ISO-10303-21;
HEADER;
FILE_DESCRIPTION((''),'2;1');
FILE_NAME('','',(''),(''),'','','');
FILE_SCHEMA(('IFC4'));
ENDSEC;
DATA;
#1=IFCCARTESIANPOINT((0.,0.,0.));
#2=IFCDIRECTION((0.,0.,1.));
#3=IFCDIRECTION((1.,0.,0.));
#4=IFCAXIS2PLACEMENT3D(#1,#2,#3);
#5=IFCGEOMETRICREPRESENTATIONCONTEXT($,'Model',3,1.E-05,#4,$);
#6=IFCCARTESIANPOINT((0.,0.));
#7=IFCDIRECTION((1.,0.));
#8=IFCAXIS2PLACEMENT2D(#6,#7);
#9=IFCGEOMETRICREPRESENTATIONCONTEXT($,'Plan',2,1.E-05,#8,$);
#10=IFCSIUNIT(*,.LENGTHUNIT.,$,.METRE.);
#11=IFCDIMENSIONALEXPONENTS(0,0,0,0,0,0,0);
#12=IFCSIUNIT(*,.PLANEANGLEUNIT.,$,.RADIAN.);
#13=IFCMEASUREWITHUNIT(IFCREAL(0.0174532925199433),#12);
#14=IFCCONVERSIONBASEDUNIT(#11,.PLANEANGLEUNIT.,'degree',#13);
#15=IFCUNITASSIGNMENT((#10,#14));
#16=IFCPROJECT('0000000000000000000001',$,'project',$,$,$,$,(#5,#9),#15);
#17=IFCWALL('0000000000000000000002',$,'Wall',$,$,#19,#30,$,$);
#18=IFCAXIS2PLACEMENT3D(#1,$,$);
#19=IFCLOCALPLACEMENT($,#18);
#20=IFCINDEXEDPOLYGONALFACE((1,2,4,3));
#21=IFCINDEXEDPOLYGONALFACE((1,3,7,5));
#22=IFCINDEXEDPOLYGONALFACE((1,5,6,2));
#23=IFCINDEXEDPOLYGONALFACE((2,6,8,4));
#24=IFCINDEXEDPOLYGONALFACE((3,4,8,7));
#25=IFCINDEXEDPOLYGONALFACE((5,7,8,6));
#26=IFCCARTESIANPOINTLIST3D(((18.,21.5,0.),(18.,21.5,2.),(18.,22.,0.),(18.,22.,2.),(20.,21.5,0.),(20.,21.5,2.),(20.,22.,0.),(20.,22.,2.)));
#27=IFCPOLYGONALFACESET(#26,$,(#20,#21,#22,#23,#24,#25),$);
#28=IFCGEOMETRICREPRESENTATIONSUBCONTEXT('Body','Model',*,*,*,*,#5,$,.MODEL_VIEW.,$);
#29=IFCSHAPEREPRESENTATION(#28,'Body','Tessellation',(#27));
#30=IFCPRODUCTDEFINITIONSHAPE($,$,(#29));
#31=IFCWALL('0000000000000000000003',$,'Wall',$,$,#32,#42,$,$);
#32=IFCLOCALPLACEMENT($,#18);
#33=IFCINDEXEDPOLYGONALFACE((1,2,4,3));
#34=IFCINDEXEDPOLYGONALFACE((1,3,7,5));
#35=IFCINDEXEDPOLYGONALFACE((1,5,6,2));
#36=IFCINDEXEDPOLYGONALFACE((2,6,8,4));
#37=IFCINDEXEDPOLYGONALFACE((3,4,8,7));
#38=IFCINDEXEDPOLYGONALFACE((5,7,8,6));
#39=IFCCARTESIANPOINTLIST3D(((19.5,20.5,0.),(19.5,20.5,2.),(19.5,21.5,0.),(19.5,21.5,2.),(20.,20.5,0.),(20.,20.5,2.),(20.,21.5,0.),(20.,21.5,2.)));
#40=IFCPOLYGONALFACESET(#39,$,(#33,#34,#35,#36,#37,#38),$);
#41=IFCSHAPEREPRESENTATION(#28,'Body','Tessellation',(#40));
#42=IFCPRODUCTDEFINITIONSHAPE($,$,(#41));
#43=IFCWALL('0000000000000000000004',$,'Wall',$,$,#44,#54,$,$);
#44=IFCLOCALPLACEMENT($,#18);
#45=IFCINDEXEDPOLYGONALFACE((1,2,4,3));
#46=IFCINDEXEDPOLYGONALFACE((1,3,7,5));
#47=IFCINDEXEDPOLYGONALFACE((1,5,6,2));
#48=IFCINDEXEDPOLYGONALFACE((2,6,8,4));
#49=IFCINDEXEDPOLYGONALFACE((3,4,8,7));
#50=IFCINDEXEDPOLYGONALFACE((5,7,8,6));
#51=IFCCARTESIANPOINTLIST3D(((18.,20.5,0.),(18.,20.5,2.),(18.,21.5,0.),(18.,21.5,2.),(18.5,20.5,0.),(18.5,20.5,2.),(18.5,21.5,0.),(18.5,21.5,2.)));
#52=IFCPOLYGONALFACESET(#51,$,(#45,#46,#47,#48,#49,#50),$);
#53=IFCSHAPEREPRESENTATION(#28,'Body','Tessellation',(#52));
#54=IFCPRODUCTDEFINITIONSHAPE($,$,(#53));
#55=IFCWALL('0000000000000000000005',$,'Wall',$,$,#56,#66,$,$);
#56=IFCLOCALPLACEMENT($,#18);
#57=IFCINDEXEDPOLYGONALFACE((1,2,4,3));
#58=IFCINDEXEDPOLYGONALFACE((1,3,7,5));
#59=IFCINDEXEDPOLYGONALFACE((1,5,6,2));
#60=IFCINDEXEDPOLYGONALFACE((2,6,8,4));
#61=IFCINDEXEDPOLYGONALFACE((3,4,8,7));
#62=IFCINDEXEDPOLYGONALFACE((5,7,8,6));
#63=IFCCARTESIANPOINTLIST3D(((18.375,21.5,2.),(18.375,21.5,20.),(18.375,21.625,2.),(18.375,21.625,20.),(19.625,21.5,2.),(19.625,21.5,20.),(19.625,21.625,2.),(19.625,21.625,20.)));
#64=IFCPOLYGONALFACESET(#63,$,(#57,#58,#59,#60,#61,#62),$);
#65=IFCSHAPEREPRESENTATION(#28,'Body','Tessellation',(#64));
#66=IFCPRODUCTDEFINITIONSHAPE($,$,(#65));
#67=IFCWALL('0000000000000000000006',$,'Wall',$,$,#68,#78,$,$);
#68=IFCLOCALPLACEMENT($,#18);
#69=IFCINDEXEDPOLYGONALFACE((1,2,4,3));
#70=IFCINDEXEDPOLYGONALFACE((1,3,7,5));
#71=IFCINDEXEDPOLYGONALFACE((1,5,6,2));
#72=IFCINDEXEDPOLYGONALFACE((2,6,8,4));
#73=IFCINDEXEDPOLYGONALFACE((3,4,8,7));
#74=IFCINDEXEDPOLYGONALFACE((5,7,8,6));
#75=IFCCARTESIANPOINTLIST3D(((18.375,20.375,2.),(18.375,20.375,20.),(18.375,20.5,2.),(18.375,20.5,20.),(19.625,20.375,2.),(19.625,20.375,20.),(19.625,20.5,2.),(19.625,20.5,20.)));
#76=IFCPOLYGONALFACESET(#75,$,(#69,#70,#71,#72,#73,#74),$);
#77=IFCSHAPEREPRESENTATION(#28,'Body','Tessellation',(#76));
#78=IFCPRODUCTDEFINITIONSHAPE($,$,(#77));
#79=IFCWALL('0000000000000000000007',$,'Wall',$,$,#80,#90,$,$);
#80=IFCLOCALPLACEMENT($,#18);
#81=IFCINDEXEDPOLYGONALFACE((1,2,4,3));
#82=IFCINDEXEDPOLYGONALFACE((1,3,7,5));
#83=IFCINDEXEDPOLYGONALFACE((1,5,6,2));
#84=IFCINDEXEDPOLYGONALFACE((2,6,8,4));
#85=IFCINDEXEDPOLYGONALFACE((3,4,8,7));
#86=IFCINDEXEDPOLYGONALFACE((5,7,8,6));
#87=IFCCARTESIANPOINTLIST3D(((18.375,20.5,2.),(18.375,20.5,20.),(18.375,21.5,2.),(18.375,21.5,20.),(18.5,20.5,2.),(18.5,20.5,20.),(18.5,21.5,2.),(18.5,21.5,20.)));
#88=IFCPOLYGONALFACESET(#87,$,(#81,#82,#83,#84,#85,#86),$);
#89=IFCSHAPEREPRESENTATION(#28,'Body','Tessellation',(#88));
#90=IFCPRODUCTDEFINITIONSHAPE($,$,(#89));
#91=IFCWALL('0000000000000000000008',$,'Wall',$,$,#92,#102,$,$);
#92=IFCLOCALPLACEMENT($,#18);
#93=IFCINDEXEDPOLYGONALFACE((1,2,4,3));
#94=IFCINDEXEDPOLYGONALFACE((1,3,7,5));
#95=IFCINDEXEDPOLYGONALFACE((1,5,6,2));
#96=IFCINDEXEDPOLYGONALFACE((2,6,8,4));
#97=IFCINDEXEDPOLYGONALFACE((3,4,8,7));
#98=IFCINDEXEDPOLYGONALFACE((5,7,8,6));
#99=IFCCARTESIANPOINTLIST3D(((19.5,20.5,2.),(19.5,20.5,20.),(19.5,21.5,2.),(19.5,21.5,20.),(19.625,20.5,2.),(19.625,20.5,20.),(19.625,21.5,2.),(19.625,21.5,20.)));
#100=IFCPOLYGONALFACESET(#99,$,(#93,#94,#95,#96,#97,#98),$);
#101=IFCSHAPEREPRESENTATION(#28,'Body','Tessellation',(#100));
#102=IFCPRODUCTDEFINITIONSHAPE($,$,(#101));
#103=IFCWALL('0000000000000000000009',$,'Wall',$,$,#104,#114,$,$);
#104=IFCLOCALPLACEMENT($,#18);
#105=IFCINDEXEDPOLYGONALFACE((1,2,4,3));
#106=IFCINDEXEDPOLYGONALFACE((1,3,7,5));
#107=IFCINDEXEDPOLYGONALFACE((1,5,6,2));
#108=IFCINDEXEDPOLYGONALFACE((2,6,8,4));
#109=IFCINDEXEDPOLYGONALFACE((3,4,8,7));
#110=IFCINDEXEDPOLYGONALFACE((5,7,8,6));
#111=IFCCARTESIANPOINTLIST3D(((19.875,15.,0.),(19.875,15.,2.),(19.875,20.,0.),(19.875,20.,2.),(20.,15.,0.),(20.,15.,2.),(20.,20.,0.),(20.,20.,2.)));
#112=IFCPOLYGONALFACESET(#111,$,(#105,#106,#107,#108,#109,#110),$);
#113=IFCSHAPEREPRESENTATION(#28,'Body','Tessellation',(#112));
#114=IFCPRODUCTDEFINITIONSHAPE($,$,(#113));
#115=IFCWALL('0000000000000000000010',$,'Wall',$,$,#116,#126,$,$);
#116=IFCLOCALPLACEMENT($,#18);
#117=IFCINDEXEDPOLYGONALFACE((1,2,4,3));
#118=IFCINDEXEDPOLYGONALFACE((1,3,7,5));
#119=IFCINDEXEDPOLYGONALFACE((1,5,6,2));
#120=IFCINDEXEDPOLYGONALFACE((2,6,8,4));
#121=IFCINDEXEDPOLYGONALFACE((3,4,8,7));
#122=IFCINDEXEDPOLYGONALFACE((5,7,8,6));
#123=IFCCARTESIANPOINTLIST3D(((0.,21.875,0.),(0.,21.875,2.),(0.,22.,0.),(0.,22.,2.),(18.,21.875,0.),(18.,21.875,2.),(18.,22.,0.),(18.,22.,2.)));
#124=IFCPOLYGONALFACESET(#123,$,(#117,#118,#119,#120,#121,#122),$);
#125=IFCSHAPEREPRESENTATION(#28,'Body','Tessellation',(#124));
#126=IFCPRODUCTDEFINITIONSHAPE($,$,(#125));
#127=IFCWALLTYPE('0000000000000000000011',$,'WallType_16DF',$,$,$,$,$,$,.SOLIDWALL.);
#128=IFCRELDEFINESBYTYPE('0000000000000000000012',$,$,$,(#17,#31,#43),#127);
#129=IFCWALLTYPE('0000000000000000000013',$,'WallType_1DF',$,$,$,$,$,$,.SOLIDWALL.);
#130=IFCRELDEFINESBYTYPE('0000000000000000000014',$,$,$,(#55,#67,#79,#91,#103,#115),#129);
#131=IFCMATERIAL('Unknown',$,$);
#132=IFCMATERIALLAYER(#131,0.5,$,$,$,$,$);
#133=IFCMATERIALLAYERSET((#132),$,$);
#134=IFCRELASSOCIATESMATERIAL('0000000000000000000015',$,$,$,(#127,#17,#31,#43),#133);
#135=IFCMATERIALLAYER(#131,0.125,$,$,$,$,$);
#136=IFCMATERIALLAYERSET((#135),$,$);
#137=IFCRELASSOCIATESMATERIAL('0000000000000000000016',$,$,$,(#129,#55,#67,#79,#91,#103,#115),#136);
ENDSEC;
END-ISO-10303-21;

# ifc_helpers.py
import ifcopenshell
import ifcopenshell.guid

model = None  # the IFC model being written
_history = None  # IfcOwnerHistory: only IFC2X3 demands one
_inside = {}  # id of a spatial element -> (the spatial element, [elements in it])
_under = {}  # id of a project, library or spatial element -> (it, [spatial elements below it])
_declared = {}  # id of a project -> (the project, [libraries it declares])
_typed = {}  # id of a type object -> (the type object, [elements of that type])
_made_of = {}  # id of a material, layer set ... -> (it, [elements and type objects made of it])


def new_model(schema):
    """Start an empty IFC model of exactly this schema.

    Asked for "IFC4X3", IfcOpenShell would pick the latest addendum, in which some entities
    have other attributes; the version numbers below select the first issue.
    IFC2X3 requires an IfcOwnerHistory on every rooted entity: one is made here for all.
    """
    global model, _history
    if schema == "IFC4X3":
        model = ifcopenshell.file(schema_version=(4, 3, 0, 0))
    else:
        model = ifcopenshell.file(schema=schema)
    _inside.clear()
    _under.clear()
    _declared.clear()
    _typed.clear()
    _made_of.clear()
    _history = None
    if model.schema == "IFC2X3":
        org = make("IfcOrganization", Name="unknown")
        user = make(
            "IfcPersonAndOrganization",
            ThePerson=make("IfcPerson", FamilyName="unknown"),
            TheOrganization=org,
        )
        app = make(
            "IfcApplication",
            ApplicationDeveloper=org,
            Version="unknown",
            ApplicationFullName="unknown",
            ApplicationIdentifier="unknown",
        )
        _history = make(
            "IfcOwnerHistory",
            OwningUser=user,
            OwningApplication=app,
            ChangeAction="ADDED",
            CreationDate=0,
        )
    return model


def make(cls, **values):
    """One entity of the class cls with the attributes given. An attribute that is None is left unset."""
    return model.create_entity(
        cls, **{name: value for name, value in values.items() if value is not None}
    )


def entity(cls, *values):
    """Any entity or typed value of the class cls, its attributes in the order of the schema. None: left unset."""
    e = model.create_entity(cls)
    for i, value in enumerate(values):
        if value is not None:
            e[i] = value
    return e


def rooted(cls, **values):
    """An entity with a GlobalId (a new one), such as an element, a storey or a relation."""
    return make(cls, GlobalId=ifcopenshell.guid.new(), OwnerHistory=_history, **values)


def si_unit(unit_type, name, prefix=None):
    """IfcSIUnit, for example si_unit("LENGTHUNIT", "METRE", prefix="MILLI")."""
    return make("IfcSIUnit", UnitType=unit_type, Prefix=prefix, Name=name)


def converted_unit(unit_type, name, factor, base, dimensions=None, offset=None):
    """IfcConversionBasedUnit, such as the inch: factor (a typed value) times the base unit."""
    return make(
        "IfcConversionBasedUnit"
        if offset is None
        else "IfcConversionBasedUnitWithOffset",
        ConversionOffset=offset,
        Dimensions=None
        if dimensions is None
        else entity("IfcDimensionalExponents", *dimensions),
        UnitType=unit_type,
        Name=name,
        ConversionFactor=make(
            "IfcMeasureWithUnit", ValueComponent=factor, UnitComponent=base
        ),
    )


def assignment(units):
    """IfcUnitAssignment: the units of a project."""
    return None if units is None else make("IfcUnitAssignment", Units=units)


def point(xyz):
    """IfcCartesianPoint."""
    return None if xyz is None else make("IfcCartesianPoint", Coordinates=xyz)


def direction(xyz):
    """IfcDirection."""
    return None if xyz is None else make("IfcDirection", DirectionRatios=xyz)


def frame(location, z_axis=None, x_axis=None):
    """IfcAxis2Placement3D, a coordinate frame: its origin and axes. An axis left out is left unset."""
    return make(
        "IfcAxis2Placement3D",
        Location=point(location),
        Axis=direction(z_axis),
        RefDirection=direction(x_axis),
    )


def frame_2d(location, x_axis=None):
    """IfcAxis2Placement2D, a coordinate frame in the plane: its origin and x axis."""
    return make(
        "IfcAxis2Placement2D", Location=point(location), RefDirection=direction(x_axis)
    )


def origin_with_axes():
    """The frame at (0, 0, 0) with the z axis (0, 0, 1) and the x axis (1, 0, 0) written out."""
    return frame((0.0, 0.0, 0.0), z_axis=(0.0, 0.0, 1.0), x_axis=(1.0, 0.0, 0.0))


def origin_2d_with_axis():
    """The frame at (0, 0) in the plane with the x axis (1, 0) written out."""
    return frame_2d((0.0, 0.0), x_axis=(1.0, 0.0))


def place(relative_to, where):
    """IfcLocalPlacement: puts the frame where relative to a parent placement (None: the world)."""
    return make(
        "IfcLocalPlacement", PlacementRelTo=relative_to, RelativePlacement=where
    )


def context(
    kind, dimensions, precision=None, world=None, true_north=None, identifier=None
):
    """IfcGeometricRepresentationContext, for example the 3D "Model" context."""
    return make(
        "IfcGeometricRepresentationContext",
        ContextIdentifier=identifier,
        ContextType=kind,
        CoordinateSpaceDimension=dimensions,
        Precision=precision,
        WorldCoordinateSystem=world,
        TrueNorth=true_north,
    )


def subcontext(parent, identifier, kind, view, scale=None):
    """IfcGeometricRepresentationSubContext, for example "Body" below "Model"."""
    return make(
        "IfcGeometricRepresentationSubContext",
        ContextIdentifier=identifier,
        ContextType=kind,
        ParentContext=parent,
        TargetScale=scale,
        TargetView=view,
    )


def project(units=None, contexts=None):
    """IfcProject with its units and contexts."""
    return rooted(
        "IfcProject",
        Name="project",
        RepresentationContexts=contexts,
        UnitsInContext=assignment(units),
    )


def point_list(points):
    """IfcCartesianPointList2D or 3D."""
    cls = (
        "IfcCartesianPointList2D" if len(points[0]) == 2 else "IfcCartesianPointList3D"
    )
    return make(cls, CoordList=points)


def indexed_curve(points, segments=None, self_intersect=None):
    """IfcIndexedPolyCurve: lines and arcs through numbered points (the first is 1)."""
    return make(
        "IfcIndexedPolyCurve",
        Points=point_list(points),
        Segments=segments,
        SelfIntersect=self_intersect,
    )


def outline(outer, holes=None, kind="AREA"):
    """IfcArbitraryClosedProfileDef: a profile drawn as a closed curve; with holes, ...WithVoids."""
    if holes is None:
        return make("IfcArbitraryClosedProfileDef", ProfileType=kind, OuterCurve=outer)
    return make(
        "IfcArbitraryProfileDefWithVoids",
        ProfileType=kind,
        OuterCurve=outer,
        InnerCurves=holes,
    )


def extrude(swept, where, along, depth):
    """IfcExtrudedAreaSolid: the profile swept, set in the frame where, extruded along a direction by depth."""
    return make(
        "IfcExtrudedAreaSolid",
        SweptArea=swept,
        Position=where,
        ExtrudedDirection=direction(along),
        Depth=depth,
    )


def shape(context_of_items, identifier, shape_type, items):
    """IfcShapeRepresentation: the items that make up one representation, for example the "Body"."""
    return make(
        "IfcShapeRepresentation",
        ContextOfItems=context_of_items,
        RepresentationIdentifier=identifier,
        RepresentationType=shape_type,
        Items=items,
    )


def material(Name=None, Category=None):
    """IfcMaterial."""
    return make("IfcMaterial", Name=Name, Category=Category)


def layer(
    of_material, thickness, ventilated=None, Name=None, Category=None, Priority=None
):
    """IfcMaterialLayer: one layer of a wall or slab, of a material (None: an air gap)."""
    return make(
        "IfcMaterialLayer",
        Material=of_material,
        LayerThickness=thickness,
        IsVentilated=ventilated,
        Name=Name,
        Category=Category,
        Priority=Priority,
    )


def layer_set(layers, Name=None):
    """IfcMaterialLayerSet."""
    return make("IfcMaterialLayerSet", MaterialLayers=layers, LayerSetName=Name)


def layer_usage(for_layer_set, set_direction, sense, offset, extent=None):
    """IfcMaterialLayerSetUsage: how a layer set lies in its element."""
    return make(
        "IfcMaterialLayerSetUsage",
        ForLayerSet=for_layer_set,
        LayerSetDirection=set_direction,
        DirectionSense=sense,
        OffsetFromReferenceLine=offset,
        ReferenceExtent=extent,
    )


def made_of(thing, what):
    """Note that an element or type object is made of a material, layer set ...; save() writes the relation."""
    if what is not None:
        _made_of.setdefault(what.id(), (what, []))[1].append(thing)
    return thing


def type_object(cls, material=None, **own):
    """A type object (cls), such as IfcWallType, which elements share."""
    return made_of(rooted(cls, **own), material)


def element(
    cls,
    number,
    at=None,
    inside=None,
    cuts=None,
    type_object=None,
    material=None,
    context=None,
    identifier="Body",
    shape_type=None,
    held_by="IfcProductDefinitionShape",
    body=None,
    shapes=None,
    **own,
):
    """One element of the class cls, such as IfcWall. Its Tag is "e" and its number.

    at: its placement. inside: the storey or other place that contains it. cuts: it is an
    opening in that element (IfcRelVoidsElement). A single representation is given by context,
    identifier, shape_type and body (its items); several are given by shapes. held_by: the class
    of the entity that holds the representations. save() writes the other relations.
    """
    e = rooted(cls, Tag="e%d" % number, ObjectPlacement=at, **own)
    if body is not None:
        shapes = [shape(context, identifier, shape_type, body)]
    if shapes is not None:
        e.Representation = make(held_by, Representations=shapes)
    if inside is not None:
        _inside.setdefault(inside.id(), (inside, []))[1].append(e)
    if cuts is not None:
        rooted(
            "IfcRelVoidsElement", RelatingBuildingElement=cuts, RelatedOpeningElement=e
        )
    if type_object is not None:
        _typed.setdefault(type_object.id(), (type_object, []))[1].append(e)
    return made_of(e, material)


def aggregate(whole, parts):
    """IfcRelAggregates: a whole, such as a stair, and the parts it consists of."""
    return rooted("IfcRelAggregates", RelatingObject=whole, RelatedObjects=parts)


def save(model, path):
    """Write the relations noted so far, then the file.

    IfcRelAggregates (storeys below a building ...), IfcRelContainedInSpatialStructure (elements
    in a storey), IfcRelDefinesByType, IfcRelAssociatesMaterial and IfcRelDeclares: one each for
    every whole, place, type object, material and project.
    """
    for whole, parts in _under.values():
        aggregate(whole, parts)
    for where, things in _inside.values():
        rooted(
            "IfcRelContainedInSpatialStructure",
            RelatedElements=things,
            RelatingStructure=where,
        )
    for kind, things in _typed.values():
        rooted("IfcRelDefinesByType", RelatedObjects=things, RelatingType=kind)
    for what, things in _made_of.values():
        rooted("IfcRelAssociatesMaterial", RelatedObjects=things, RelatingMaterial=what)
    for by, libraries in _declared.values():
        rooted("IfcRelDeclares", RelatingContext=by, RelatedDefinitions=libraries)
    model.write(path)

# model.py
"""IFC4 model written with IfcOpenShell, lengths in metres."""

from ifc_helpers import new_model, entity, si_unit, converted_unit, frame, origin_with_axes, origin_2d_with_axis, place, context, subcontext, project, indexed_curve, outline, extrude, material, layer, layer_set, layer_usage, type_object, element, save


model = new_model("IFC4")

# Units and contexts
model_context = context("Model", 3, precision=1e-05, world=origin_with_axes())
plan_context = context("Plan", 2, precision=1e-05, world=origin_2d_with_axis())
body_context_1 = subcontext(model_context, "Body", "Model", "MODEL_VIEW")
ifc_project = project(units=[si_unit("LENGTHUNIT", "METRE"), converted_unit("PLANEANGLEUNIT", "degree", entity("IfcReal", 0.0174532925199433), si_unit("PLANEANGLEUNIT", "RADIAN"), dimensions=[0, 0, 0, 0, 0, 0, 0])], contexts=[model_context, plan_context])

# Walls
ifc_material = material(Name="Unknown")
ifc_layer_1 = layer(ifc_material, 0.5)
ifc_layer_set_1 = layer_set([ifc_layer_1])
ifc_layer_usage_1 = layer_usage(ifc_layer_set_1, "AXIS2", "POSITIVE", 0.0)
wall_type_1 = type_object("IfcWallType", Name="WallType_16DF", PredefinedType="SOLIDWALL", material=ifc_layer_set_1)
wall_1_placement = place(None, frame((18.0, 21.5, 0.0), z_axis=(0.0, 0.0, 1.0), x_axis=(1.0, 0.0, 0.0)))
element("IfcWall", 1, at=wall_1_placement, type_object=wall_type_1, material=ifc_layer_usage_1, Name="Wall", context=body_context_1, shape_type="SweptSolid", body=[
    extrude(outline(indexed_curve([(0.0, 0.0), (0.0, 0.5), (2.0, 0.5), (2.0, 0.0), (0.0, 0.0)], self_intersect=False)), origin_with_axes(), (0.0, 0.0, 1.0), 2.0),
])
ifc_layer_usage_2 = layer_usage(ifc_layer_set_1, "AXIS2", "POSITIVE", 0.0)
wall_2_placement = place(None, frame((20.0, 20.5, 0.0), z_axis=(0.0, 0.0, 1.0), x_axis=(0.0, 1.0, 0.0)))
element("IfcWall", 2, at=wall_2_placement, type_object=wall_type_1, material=ifc_layer_usage_2, Name="Wall", context=body_context_1, shape_type="SweptSolid", body=[
    extrude(outline(indexed_curve([(0.0, 0.0), (0.0, 0.5), (1.0, 0.5), (1.0, 0.0), (0.0, 0.0)], self_intersect=False)), origin_with_axes(), (0.0, 0.0, 1.0), 2.0),
])
ifc_layer_usage_3 = layer_usage(ifc_layer_set_1, "AXIS2", "POSITIVE", 0.0)
wall_3_placement = place(None, frame((18.0, 21.5, 0.0), z_axis=(0.0, 0.0, 1.0), x_axis=(0.0, -1.0, 0.0)))
element("IfcWall", 3, at=wall_3_placement, type_object=wall_type_1, material=ifc_layer_usage_3, Name="Wall", context=body_context_1, shape_type="SweptSolid", body=[
    extrude(outline(indexed_curve([(0.0, 0.0), (0.0, 0.5), (1.0, 0.5), (1.0, 0.0), (0.0, 0.0)], self_intersect=False)), origin_with_axes(), (0.0, 0.0, 1.0), 2.0),
])
ifc_layer_2 = layer(ifc_material, 0.125)
ifc_layer_set_2 = layer_set([ifc_layer_2])
ifc_layer_usage_4 = layer_usage(ifc_layer_set_2, "AXIS2", "POSITIVE", 0.0)
wall_type_2 = type_object("IfcWallType", Name="WallType_1DF", PredefinedType="SOLIDWALL", material=ifc_layer_set_2)
wall_4_placement = place(None, frame((18.375, 21.5, 2.0), z_axis=(0.0, 0.0, 1.0), x_axis=(1.0, 0.0, 0.0)))
element("IfcWall", 4, at=wall_4_placement, type_object=wall_type_2, material=ifc_layer_usage_4, Name="Wall", context=body_context_1, shape_type="SweptSolid", body=[
    extrude(outline(indexed_curve([(0.0, 0.0), (0.0, 0.125), (1.25, 0.125), (1.25, 0.0), (0.0, 0.0)], self_intersect=False)), origin_with_axes(), (0.0, 0.0, 1.0), 18.0),
])
ifc_layer_usage_5 = layer_usage(ifc_layer_set_2, "AXIS2", "POSITIVE", 0.0)
wall_5_placement = place(None, frame((18.375, 20.375, 2.0), z_axis=(0.0, 0.0, 1.0), x_axis=(1.0, 0.0, 0.0)))
element("IfcWall", 5, at=wall_5_placement, type_object=wall_type_2, material=ifc_layer_usage_5, Name="Wall", context=body_context_1, shape_type="SweptSolid", body=[
    extrude(outline(indexed_curve([(0.0, 0.0), (0.0, 0.125), (1.25, 0.125), (1.25, 0.0), (0.0, 0.0)], self_intersect=False)), origin_with_axes(), (0.0, 0.0, 1.0), 18.0),
])
ifc_layer_usage_6 = layer_usage(ifc_layer_set_2, "AXIS2", "POSITIVE", 0.0)
wall_6_placement = place(None, frame((18.5, 20.5, 2.0), z_axis=(0.0, 0.0, 1.0), x_axis=(0.0, 1.0, 0.0)))
element("IfcWall", 6, at=wall_6_placement, type_object=wall_type_2, material=ifc_layer_usage_6, Name="Wall", context=body_context_1, shape_type="SweptSolid", body=[
    extrude(outline(indexed_curve([(0.0, 0.0), (0.0, 0.125), (1.0, 0.125), (1.0, 0.0), (0.0, 0.0)], self_intersect=False)), origin_with_axes(), (0.0, 0.0, 1.0), 18.0),
])
ifc_layer_usage_7 = layer_usage(ifc_layer_set_2, "AXIS2", "POSITIVE", 0.0)
wall_7_placement = place(None, frame((19.625, 20.5, 2.0), z_axis=(0.0, 0.0, 1.0), x_axis=(0.0, 1.0, 0.0)))
element("IfcWall", 7, at=wall_7_placement, type_object=wall_type_2, material=ifc_layer_usage_7, Name="Wall", context=body_context_1, shape_type="SweptSolid", body=[
    extrude(outline(indexed_curve([(0.0, 0.0), (0.0, 0.125), (1.0, 0.125), (1.0, 0.0), (0.0, 0.0)], self_intersect=False)), origin_with_axes(), (0.0, 0.0, 1.0), 18.0),
])
ifc_layer_usage_8 = layer_usage(ifc_layer_set_2, "AXIS2", "POSITIVE", 0.0)
wall_8_placement = place(None, frame((20.0, 15.0, 0.0), z_axis=(0.0, 0.0, 1.0), x_axis=(0.0, 1.0, 0.0)))
element("IfcWall", 8, at=wall_8_placement, type_object=wall_type_2, material=ifc_layer_usage_8, Name="Wall", context=body_context_1, shape_type="SweptSolid", body=[
    extrude(outline(indexed_curve([(0.0, 0.0), (0.0, 0.125), (5.0, 0.125), (5.0, 0.0), (0.0, 0.0)], self_intersect=False)), origin_with_axes(), (0.0, 0.0, 1.0), 2.0),
])
ifc_layer_usage_9 = layer_usage(ifc_layer_set_2, "AXIS2", "POSITIVE", 0.0)
wall_9_placement = place(None, frame((18.0, 22.0, 0.0), z_axis=(0.0, 0.0, 1.0), x_axis=(-1.0, 0.0, 0.0)))
element("IfcWall", 9, at=wall_9_placement, type_object=wall_type_2, material=ifc_layer_usage_9, Name="Wall", context=body_context_1, shape_type="SweptSolid", body=[
    extrude(outline(indexed_curve([(0.0, 0.0), (0.0, 0.125), (18.0, 0.125), (18.0, 0.0), (0.0, 0.0)], self_intersect=False)), origin_with_axes(), (0.0, 0.0, 1.0), 2.0),
])

save(model, "model.ifc")
